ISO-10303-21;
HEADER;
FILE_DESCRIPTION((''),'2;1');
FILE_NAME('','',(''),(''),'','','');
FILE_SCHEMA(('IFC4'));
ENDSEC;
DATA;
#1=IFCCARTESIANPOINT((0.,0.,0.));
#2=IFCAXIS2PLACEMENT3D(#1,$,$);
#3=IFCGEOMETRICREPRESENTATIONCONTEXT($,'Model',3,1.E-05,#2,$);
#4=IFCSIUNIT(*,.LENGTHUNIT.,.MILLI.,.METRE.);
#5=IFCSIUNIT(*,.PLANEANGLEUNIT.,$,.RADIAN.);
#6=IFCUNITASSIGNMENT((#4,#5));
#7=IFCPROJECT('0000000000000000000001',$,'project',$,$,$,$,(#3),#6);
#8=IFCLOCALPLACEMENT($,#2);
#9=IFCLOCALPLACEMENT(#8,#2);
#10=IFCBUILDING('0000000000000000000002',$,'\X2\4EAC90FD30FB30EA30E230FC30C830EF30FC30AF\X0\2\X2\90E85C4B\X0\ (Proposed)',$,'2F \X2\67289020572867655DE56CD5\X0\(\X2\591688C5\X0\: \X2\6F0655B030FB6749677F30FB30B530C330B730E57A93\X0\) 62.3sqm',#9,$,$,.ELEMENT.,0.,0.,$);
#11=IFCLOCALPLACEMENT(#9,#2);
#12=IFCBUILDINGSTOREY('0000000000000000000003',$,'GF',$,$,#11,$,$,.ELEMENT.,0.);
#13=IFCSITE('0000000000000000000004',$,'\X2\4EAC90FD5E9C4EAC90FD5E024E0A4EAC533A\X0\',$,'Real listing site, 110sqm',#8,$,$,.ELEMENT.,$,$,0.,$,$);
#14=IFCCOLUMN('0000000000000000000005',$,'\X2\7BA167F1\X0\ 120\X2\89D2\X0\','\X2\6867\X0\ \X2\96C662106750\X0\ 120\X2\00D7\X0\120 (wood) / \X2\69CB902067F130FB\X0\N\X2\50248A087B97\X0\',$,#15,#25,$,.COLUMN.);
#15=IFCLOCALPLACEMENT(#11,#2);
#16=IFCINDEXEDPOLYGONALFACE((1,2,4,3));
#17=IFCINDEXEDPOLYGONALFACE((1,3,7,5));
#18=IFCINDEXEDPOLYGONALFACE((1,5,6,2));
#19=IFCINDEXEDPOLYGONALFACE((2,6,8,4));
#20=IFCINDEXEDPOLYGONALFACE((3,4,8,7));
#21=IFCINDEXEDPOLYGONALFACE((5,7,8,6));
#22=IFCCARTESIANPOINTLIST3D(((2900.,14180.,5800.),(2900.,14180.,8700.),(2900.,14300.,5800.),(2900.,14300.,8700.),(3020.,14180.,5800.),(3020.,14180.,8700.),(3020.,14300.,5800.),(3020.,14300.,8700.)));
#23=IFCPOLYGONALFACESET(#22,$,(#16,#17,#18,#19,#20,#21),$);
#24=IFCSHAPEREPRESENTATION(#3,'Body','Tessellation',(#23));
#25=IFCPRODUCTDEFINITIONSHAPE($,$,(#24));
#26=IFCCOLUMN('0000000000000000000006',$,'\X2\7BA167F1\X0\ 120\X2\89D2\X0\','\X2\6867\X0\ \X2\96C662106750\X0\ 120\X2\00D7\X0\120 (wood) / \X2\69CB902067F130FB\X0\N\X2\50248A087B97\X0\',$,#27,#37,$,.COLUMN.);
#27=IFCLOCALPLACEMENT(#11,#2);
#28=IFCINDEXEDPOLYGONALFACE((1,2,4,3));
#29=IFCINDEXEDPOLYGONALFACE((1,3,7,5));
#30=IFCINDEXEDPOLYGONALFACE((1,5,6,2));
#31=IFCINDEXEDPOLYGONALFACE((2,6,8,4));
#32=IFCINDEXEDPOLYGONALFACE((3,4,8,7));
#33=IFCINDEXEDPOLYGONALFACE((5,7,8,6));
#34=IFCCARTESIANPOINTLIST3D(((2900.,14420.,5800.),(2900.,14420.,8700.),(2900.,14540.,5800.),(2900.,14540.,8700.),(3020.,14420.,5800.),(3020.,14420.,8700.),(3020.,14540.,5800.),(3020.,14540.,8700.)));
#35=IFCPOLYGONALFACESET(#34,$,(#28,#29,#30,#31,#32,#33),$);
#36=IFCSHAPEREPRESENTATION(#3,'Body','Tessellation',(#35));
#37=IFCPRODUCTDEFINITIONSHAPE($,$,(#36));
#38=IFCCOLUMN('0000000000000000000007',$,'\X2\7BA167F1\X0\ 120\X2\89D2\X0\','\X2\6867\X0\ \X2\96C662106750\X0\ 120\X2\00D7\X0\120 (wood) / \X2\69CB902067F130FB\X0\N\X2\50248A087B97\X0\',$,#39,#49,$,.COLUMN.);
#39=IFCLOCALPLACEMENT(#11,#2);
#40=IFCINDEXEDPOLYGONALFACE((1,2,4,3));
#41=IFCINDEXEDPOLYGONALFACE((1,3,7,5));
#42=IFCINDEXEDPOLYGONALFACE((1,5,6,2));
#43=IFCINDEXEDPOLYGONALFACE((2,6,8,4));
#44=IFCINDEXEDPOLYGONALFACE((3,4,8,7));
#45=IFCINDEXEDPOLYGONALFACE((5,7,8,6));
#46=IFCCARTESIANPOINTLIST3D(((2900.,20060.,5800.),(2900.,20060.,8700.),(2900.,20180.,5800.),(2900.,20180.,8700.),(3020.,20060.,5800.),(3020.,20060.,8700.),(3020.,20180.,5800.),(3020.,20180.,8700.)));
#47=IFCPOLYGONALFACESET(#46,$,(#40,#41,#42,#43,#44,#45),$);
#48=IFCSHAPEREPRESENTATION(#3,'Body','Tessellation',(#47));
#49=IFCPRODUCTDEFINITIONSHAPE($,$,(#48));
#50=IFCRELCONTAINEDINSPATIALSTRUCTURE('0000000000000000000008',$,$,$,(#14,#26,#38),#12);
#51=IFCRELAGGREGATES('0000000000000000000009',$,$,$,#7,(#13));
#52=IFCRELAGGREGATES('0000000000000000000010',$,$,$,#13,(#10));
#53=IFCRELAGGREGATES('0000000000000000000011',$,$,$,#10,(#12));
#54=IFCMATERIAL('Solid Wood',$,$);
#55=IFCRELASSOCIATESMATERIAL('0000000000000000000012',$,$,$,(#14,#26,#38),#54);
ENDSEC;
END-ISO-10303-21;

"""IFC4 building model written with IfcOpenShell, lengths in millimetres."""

from ifc_helpers import new_model, si_unit, frame, frame_2d, origin, place, context, project, spatial, rectangle, extrude, material, element, save


model = new_model("IFC4")

# Units and contexts
model_context = context("Model", 3, precision=1e-05, world=origin())
ifc_project = project(units=[si_unit("LENGTHUNIT", "METRE", prefix="MILLI"), si_unit("PLANEANGLEUNIT", "RADIAN")], contexts=[model_context])

# Site, building, storey
site_placement = place(None, origin())
site = spatial("IfcSite", under=ifc_project, at=site_placement, Name="京都府京都市上京区", ObjectType="Real listing site, 110sqm", CompositionType="ELEMENT", RefElevation=0.0)
building_placement = place(site_placement, origin())
building = spatial("IfcBuilding", under=site, at=building_placement, Name="京都・リモートワーク2部屋 (Proposed)", ObjectType="2F 木造在来工法(外装: 漆喰・杉板・サッシュ窓) 62.3sqm", CompositionType="ELEMENT", ElevationOfRefHeight=0.0, ElevationOfTerrain=0.0)
storey_placement = place(building_placement, origin())
storey = spatial("IfcBuildingStorey", under=building, at=storey_placement, Name="GF", CompositionType="ELEMENT", Elevation=0.0)

# Columns
ifc_material_1 = material(Name="Solid Wood")
column_1_placement = place(storey_placement, frame((1450.0, 7090.0, 2900.0)))
element("IfcColumn", 1, at=column_1_placement, inside=storey, material=ifc_material_1, Name="管柱 120角", Description="桧 集成材 120×120 (wood) / 構造柱・N値計算", PredefinedType="COLUMN", context=model_context, shape_type="SweptSolid", body=[
    extrude(rectangle(XDim=120.0, YDim=120.0, at=frame_2d((60.0, 60.0))), frame((1450.0, 7090.0, 2900.0)), (0.0, 0.0, 1.0), 2900.0),
])
column_2_placement = place(storey_placement, frame((1450.0, 7210.0, 2900.0)))
element("IfcColumn", 2, at=column_2_placement, inside=storey, material=ifc_material_1, Name="管柱 120角", Description="桧 集成材 120×120 (wood) / 構造柱・N値計算", PredefinedType="COLUMN", context=model_context, shape_type="SweptSolid", body=[
    extrude(rectangle(XDim=120.0, YDim=120.0, at=frame_2d((60.0, 60.0))), frame((1450.0, 7210.0, 2900.0)), (0.0, 0.0, 1.0), 2900.0),
])
column_3_placement = place(storey_placement, frame((1450.0, 10030.0, 2900.0)))
element("IfcColumn", 3, at=column_3_placement, inside=storey, material=ifc_material_1, Name="管柱 120角", Description="桧 集成材 120×120 (wood) / 構造柱・N値計算", PredefinedType="COLUMN", context=model_context, shape_type="SweptSolid", body=[
    extrude(rectangle(XDim=120.0, YDim=120.0, at=frame_2d((60.0, 60.0))), frame((1450.0, 10030.0, 2900.0)), (0.0, 0.0, 1.0), 2900.0),
])

save(model, "model.ifc")
